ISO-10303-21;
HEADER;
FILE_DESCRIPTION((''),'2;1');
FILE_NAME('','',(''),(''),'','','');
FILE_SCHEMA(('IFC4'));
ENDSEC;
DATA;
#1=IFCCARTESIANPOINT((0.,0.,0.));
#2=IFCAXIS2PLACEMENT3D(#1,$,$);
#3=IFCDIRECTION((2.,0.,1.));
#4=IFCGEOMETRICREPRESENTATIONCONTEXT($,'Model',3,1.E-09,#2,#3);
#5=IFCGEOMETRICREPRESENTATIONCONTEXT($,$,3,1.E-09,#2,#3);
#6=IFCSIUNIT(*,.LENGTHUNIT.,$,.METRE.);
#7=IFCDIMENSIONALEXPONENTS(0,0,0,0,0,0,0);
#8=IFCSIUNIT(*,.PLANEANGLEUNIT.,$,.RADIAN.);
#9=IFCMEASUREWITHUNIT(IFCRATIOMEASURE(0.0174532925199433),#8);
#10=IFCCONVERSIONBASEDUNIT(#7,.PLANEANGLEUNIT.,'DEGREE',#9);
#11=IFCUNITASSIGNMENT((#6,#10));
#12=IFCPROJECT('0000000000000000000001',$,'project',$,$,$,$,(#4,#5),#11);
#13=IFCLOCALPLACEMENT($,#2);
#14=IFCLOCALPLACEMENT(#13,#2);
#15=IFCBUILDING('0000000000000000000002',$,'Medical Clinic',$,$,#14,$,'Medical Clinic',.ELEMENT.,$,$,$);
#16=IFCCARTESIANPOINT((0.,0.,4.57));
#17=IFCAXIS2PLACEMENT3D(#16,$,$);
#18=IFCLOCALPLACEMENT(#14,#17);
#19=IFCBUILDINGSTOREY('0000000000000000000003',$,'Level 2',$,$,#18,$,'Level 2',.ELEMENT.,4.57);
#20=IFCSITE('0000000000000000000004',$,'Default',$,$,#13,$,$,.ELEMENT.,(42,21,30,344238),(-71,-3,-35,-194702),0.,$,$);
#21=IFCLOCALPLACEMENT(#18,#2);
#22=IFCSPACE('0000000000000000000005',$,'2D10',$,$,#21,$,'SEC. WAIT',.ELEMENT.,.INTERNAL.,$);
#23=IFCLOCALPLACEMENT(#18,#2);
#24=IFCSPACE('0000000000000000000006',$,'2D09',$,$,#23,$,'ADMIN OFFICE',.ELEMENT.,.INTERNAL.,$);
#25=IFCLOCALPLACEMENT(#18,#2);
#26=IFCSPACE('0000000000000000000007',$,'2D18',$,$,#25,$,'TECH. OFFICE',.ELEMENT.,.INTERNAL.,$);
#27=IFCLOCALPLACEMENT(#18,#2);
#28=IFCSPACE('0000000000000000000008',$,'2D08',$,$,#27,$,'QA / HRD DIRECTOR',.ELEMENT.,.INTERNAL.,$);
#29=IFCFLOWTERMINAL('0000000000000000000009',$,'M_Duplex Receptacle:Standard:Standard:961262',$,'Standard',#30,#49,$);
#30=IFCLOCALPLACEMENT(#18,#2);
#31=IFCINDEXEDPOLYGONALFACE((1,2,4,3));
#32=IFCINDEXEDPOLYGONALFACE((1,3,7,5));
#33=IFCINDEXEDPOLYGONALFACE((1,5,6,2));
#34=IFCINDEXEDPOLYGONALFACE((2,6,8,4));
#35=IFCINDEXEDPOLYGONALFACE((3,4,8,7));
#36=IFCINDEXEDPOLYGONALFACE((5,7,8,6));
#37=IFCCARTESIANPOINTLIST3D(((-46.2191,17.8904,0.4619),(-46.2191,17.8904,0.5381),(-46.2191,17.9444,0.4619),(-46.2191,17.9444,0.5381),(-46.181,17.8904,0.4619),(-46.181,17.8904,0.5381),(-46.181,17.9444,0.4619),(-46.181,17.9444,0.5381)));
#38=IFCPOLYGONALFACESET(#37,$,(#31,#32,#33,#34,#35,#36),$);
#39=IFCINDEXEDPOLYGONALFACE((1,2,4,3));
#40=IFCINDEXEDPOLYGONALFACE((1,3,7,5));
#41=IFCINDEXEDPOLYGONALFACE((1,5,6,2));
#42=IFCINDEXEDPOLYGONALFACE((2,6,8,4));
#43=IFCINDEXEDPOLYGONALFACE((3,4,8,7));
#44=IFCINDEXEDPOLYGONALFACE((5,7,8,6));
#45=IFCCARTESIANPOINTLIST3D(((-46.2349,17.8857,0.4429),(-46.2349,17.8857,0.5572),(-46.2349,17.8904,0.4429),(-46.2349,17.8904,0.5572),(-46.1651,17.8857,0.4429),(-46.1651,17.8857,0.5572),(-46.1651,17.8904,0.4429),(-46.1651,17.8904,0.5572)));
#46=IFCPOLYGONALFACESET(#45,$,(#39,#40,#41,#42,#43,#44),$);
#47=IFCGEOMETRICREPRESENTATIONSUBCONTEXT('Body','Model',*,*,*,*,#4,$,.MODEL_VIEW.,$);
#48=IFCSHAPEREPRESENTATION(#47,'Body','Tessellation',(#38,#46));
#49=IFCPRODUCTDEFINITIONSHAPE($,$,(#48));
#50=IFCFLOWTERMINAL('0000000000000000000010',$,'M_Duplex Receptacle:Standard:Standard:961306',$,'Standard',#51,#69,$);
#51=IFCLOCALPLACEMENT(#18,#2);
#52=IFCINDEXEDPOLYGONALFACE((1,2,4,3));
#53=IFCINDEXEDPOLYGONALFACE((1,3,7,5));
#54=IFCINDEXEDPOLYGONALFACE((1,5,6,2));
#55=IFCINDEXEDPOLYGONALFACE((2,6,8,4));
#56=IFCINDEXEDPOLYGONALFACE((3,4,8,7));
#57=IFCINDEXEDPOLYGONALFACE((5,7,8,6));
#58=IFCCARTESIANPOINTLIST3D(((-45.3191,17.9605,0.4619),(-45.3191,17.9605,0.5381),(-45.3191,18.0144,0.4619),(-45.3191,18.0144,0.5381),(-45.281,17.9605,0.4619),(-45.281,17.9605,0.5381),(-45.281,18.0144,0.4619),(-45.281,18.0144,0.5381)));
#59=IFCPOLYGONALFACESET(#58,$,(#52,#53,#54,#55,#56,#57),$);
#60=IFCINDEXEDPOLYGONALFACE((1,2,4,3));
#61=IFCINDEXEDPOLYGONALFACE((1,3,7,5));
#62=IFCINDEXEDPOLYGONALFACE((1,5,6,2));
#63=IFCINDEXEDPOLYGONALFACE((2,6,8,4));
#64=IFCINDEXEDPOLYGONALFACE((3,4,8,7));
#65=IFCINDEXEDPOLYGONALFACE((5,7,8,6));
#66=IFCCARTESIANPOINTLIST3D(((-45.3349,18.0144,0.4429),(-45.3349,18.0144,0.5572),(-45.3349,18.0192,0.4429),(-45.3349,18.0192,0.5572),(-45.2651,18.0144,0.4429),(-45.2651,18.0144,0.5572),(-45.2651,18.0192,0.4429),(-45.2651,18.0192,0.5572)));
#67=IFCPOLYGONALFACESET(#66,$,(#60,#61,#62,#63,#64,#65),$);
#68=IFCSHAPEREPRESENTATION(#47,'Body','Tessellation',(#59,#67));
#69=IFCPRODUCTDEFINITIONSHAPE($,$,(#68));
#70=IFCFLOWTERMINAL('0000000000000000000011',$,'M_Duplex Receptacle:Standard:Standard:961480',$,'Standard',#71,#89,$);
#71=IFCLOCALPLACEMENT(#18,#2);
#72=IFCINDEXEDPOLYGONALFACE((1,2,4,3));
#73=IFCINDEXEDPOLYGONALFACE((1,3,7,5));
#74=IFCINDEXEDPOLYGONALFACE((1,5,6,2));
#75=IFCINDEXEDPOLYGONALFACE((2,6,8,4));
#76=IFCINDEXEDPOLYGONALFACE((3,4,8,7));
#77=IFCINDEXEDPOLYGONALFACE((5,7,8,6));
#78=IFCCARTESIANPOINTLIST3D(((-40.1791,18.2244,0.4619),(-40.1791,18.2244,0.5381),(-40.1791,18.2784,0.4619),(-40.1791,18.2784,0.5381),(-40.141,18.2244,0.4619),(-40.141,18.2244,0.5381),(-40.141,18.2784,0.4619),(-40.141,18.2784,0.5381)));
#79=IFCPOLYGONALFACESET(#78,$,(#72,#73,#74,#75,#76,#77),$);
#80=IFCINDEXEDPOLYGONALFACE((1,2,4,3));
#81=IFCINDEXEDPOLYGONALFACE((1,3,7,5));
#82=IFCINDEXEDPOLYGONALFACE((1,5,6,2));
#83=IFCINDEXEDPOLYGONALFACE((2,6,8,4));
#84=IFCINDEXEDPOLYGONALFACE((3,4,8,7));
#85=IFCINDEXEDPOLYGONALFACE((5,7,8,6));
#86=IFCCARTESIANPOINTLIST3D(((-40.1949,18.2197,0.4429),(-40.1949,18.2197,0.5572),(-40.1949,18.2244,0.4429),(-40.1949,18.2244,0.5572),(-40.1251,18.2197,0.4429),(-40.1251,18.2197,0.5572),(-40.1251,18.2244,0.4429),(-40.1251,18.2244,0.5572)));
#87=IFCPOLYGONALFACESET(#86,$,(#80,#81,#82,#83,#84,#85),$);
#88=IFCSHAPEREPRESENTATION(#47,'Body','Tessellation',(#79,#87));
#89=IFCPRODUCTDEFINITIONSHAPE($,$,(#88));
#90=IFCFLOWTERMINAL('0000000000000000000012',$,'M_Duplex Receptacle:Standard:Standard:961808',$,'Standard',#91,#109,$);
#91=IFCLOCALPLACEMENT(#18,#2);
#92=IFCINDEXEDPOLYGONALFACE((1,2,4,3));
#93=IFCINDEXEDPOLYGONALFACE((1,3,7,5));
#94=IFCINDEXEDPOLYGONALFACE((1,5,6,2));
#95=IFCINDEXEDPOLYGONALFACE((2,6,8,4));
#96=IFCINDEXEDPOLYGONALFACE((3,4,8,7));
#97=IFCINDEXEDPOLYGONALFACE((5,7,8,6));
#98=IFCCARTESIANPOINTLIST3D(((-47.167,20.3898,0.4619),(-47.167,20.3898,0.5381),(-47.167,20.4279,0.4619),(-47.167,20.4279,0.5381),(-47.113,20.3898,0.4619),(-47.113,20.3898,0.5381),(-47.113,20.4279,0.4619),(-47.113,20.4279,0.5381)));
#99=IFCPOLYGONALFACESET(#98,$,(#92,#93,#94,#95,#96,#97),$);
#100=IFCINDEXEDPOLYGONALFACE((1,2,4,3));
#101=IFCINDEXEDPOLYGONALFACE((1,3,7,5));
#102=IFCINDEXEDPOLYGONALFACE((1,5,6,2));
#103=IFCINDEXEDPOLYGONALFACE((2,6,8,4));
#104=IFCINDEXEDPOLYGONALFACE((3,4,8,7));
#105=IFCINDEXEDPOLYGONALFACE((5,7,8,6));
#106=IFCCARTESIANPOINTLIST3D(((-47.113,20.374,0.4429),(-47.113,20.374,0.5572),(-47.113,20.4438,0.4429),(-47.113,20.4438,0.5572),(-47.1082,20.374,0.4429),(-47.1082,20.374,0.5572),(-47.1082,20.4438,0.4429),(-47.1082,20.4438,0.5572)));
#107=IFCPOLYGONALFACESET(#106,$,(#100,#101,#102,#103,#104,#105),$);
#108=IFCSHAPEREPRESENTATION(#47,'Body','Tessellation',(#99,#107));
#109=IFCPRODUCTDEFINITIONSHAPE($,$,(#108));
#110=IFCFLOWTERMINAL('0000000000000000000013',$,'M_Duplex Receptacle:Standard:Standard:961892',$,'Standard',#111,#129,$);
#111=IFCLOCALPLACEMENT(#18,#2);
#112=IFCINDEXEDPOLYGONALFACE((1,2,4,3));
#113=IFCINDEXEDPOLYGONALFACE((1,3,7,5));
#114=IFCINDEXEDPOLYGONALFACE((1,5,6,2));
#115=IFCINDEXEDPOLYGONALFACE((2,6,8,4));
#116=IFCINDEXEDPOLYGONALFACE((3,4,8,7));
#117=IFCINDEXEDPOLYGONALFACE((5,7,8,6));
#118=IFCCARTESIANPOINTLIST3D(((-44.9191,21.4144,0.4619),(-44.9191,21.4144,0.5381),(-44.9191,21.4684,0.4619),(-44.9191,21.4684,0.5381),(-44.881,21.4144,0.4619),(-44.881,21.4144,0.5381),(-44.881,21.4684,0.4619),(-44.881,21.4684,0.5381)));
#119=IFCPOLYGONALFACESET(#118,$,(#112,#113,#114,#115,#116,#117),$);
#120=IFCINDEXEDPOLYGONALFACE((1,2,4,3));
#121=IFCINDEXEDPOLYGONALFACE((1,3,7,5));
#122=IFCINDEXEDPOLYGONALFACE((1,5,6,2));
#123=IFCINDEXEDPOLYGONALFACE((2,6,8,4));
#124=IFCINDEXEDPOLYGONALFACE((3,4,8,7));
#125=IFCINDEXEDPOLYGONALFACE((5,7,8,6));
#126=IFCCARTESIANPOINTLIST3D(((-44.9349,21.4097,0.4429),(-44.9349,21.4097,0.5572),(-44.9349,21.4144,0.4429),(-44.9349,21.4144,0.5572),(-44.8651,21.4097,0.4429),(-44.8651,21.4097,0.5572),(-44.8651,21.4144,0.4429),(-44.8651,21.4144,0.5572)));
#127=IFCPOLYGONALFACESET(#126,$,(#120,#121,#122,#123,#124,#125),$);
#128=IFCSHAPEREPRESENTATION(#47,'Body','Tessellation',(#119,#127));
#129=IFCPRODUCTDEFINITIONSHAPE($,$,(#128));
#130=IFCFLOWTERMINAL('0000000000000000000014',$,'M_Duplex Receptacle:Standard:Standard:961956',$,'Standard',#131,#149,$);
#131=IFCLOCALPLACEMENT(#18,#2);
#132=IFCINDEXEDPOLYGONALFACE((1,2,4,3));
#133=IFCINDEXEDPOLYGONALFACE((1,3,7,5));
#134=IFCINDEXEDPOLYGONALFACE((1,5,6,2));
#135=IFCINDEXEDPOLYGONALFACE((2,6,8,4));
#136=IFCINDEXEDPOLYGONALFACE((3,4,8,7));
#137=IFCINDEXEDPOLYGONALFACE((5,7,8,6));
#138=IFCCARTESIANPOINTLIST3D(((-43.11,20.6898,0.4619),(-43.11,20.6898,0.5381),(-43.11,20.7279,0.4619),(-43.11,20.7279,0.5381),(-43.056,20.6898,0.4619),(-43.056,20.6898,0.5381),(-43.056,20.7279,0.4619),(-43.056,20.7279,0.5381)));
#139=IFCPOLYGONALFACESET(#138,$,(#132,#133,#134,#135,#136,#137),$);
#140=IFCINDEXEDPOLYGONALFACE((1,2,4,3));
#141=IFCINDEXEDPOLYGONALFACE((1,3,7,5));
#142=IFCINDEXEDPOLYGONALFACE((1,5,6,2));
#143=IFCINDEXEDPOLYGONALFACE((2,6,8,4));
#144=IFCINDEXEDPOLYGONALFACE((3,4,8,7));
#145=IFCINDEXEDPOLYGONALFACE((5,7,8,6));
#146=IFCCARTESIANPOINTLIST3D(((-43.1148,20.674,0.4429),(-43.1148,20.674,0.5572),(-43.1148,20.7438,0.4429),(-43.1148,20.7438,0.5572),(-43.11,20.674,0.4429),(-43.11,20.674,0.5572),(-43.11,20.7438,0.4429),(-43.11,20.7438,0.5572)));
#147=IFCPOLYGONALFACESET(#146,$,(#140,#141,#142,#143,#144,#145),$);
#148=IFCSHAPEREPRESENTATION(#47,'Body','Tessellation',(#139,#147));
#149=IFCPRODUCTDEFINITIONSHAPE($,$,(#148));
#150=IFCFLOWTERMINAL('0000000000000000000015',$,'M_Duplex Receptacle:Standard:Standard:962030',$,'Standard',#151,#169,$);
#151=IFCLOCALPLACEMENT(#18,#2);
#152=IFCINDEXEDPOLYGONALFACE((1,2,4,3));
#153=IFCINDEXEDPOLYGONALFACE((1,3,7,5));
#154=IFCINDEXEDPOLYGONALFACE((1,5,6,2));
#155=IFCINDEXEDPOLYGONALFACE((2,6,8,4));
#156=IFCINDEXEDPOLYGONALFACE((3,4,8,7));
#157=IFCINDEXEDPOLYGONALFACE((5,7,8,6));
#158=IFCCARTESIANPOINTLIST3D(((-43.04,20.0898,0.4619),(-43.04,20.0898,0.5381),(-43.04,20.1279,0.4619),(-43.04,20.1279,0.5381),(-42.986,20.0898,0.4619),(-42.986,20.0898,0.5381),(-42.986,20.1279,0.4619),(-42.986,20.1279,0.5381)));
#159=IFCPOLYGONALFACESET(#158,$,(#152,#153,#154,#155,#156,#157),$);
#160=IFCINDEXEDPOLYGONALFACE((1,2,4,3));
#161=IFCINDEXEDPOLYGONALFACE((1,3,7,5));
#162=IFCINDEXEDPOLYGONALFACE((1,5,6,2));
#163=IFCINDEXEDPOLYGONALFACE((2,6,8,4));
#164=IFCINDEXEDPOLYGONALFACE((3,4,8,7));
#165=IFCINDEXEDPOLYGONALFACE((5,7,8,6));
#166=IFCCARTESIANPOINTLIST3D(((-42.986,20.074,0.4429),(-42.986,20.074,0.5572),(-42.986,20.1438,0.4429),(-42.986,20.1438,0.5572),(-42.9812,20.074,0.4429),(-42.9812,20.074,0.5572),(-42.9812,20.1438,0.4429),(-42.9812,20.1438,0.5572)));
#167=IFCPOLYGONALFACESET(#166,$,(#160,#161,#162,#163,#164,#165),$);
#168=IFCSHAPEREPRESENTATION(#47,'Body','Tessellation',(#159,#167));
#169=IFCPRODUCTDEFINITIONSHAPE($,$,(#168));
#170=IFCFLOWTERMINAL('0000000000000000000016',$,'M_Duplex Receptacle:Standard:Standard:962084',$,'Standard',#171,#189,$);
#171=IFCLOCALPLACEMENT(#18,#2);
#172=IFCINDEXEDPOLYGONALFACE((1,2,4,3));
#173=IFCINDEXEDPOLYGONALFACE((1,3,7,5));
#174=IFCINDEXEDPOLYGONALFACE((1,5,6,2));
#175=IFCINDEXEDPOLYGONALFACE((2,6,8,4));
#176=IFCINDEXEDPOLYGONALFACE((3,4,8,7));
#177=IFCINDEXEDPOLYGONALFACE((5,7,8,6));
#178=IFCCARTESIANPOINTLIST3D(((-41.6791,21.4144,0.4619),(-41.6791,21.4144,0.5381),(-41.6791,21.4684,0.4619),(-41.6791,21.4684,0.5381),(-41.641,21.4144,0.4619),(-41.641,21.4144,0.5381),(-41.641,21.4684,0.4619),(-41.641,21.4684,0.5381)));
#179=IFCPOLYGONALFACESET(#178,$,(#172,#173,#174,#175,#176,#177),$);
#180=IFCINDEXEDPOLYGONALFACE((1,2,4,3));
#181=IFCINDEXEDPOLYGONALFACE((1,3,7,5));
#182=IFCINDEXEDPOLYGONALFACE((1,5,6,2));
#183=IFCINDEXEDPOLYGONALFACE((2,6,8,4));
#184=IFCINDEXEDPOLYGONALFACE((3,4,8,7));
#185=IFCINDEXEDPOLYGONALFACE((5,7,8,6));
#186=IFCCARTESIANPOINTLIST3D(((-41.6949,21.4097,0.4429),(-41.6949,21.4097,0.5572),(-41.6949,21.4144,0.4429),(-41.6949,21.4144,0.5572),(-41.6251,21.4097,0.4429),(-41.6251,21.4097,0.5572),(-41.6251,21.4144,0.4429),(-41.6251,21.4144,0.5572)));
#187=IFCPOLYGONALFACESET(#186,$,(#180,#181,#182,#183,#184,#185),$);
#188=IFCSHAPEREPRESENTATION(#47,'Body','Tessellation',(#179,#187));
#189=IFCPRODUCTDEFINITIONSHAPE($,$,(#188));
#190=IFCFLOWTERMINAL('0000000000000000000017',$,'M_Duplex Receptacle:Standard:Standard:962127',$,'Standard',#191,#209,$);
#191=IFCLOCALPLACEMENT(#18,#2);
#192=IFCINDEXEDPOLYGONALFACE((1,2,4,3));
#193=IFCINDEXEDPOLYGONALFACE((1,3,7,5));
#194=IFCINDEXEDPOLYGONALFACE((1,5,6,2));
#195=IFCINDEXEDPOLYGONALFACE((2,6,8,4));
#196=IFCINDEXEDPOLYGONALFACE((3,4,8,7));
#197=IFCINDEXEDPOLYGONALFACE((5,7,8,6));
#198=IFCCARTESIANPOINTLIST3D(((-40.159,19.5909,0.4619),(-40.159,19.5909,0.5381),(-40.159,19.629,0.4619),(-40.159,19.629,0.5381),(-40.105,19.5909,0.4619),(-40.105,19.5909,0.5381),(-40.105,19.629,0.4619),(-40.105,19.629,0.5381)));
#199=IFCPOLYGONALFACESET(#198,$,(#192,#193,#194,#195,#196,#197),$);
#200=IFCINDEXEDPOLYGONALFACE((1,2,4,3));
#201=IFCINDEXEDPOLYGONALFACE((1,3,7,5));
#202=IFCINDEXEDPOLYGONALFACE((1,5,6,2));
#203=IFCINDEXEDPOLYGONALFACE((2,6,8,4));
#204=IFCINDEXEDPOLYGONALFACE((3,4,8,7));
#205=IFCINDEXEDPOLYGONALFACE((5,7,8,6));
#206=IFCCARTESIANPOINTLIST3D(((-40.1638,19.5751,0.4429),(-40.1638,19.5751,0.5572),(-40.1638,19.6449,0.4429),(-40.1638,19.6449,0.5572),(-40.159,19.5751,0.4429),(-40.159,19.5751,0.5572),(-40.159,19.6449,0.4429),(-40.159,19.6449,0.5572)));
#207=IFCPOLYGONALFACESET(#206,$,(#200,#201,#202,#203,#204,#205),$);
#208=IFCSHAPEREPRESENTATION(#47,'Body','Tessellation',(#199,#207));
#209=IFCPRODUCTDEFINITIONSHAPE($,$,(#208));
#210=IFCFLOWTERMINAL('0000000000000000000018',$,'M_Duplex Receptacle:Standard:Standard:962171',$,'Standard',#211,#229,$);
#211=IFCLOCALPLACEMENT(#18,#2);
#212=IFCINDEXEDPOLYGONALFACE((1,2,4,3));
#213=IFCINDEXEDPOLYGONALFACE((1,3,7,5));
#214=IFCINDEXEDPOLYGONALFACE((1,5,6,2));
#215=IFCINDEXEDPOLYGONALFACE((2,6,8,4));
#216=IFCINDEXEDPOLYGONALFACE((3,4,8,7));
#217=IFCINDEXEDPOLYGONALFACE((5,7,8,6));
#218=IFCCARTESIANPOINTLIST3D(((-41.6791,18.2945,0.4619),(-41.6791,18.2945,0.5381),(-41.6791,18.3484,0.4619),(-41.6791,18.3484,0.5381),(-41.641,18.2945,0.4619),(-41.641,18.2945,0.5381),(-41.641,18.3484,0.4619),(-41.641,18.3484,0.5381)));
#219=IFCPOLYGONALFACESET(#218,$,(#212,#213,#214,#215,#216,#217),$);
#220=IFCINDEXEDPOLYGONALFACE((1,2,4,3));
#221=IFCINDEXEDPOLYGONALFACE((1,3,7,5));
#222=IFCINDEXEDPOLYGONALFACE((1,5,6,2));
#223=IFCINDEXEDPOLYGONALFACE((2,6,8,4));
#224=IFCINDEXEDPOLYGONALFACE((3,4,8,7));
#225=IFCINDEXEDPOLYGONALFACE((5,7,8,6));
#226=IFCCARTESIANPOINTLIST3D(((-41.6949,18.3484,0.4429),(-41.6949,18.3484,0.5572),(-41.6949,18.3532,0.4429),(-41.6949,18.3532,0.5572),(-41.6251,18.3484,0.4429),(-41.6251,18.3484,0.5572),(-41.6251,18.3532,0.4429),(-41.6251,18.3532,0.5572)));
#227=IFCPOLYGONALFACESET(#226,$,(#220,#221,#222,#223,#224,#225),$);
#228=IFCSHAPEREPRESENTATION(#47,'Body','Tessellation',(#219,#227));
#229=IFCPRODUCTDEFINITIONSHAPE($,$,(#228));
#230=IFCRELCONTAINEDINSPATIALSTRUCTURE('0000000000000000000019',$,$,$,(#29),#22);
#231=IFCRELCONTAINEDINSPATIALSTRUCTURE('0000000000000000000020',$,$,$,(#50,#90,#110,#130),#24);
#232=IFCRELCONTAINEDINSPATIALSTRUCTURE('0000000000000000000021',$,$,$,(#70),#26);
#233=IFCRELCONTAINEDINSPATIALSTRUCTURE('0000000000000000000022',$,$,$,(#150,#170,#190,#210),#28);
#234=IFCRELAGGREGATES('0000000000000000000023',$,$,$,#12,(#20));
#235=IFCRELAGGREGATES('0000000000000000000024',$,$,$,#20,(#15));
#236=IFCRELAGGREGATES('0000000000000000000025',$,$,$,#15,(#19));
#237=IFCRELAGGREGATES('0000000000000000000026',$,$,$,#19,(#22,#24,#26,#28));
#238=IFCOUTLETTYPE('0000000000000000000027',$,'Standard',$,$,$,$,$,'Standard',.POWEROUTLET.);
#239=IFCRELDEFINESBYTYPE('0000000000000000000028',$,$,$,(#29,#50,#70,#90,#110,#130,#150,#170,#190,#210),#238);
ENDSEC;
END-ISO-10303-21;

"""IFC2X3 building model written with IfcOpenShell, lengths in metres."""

from ifc_helpers import new_model, entity, si_unit, converted_unit, direction, frame, frame_2d, origin, origin_2d_with_axis, place, context, subcontext, project, spatial, rectangle, extrude, source, transform, mapped, type_object, type_shapes, element, save


model = new_model("IFC2X3")

# Units and contexts
model_context = context("Model", 3, precision=1e-09, world=origin(), true_north=direction((2.0, 0.0, 1.0)))
context_of_model = context(None, 3, precision=1e-09, world=origin(), true_north=direction((2.0, 0.0, 1.0)))
body_context = subcontext(model_context, "Body", "Model", "MODEL_VIEW")
ifc_project = project(units=[si_unit("LENGTHUNIT", "METRE"), converted_unit("PLANEANGLEUNIT", "DEGREE", entity("IfcRatioMeasure", 0.0174532925199433), si_unit("PLANEANGLEUNIT", "RADIAN"), dimensions=[0, 0, 0, 0, 0, 0, 0])], contexts=[model_context, context_of_model])

# Site, building, storey, space
site_placement = place(None, origin())
site = spatial("IfcSite", under=ifc_project, at=site_placement, Name="Default", CompositionType="ELEMENT", RefLatitude=(42, 21, 30, 344238), RefLongitude=(-71, -3, -35, -194702), RefElevation=0.0)
building_placement = place(site_placement, origin())
building = spatial("IfcBuilding", under=site, at=building_placement, Name="Medical Clinic", LongName="Medical Clinic", CompositionType="ELEMENT")
storey_placement = place(building_placement, frame((0.0, 0.0, 4.57)))
storey = spatial("IfcBuildingStorey", under=building, at=storey_placement, Name="Level 2", LongName="Level 2", CompositionType="ELEMENT", Elevation=4.57)
space_1_placement = place(storey_placement, origin())
space_1 = spatial("IfcSpace", under=storey, at=space_1_placement, Name="2D10", LongName="SEC. WAIT", CompositionType="ELEMENT", InteriorOrExteriorSpace="INTERNAL")

# Flow terminal
outlet_type = type_object("IfcOutletType", Name="Standard", ElementType="Standard", PredefinedType="POWEROUTLET")
shared_shape_1 = source(origin(), body_context, "Body", "SweptSolid", [
    extrude(rectangle(XDim=0.0381, YDim=0.0762, at=origin_2d_with_axis()), frame((0.0, 0.0, -0.054), z_axis=(0.0, 0.0, 1.0), x_axis=(-1.0, 0.0, 0.0)), (0.0, 0.0, 1.0), 0.054),
    extrude(rectangle(XDim=0.0698, YDim=0.1143, at=frame_2d((0.0, 0.0), x_axis=(1.0, 0.0))), frame((0.0, 0.0, 0.0), z_axis=(0.0, 0.0, 1.0), x_axis=(-1.0, 0.0, 0.0)), (0.0, 0.0, 1.0), 0.0048),
])
type_shapes(outlet_type, [shared_shape_1])
flow_terminal_1_placement = place(space_1_placement, frame((-46.2, 17.8904, 0.5), z_axis=(0.0, -1.0, 0.0), x_axis=(1.0, 0.0, 0.0)))
element("IfcFlowTerminal", 1, at=flow_terminal_1_placement, inside=space_1, type_object=outlet_type, Name="M_Duplex Receptacle:Standard:Standard:961262", ObjectType="Standard", context=body_context, shape_type="MappedRepresentation", body=[
    mapped(shared_shape_1, transform((0.0, 0.0, 0.0), scale=1.0)),
])

# Shared definitions
space_2_placement = place(storey_placement, origin())
space_2 = spatial("IfcSpace", under=storey, at=space_2_placement, Name="2D09", LongName="ADMIN OFFICE", CompositionType="ELEMENT", InteriorOrExteriorSpace="INTERNAL")

# Flow terminal
flow_terminal_2_placement = place(space_2_placement, frame((-45.3, 18.0144, 0.5), z_axis=(0.0, 1.0, 0.0), x_axis=(-1.0, 0.0, 0.0)))
element("IfcFlowTerminal", 2, at=flow_terminal_2_placement, inside=space_2, type_object=outlet_type, Name="M_Duplex Receptacle:Standard:Standard:961306", ObjectType="Standard", context=body_context, shape_type="MappedRepresentation", body=[
    mapped(shared_shape_1, transform((0.0, 0.0, 0.0), scale=1.0)),
])

# Shared definitions
space_3_placement = place(storey_placement, origin())
space_3 = spatial("IfcSpace", under=storey, at=space_3_placement, Name="2D18", LongName="TECH. OFFICE", CompositionType="ELEMENT", InteriorOrExteriorSpace="INTERNAL")

# Flow terminals
flow_terminal_3_placement = place(space_3_placement, frame((-40.16, 18.2244, 0.5), z_axis=(0.0, -1.0, 0.0), x_axis=(1.0, 0.0, 0.0)))
element("IfcFlowTerminal", 3, at=flow_terminal_3_placement, inside=space_3, type_object=outlet_type, Name="M_Duplex Receptacle:Standard:Standard:961480", ObjectType="Standard", context=body_context, shape_type="MappedRepresentation", body=[
    mapped(shared_shape_1, transform((0.0, 0.0, 0.0), scale=1.0)),
])
for number, where, z_axis, x_axis, name in (
    (4, (-47.113, 20.4089, 0.5), (1.0, 0.0, 0.0), (0.0, 1.0, 0.0), "M_Duplex Receptacle:Standard:Standard:961808"),
    (5, (-44.9, 21.4144, 0.5), (0.0, -1.0, 0.0), (1.0, 0.0, 0.0), "M_Duplex Receptacle:Standard:Standard:961892"),
    (6, (-43.11, 20.7089, 0.5), (-1.0, 0.0, 0.0), (0.0, -1.0, 0.0), "M_Duplex Receptacle:Standard:Standard:961956"),
):
    element("IfcFlowTerminal", number, at=place(space_2_placement, frame(where, z_axis=z_axis, x_axis=x_axis)), inside=space_2, type_object=outlet_type, Name=name, ObjectType="Standard", context=body_context, shape_type="MappedRepresentation", body=[
        mapped(shared_shape_1, transform((0.0, 0.0, 0.0), scale=1.0)),
    ])

# Shared definitions
space_4_placement = place(storey_placement, origin())
space_4 = spatial("IfcSpace", under=storey, at=space_4_placement, Name="2D08", LongName="QA / HRD DIRECTOR", CompositionType="ELEMENT", InteriorOrExteriorSpace="INTERNAL")

# Flow terminals
for number, where, z_axis, x_axis, name in (
    (7, (-42.986, 20.1089, 0.5), (1.0, 0.0, 0.0), (0.0, 1.0, 0.0), "M_Duplex Receptacle:Standard:Standard:962030"),
    (8, (-41.66, 21.4144, 0.5), (0.0, -1.0, 0.0), (1.0, 0.0, 0.0), "M_Duplex Receptacle:Standard:Standard:962084"),
    (9, (-40.159, 19.61, 0.5), (-1.0, 0.0, 0.0), (0.0, -1.0, 0.0), "M_Duplex Receptacle:Standard:Standard:962127"),
    (10, (-41.66, 18.3484, 0.5), (0.0, 1.0, 0.0), (-1.0, 0.0, 0.0), "M_Duplex Receptacle:Standard:Standard:962171"),
):
    element("IfcFlowTerminal", number, at=place(space_4_placement, frame(where, z_axis=z_axis, x_axis=x_axis)), inside=space_4, type_object=outlet_type, Name=name, ObjectType="Standard", context=body_context, shape_type="MappedRepresentation", body=[
        mapped(shared_shape_1, transform((0.0, 0.0, 0.0), scale=1.0)),
    ])

save(model, "model.ifc")
